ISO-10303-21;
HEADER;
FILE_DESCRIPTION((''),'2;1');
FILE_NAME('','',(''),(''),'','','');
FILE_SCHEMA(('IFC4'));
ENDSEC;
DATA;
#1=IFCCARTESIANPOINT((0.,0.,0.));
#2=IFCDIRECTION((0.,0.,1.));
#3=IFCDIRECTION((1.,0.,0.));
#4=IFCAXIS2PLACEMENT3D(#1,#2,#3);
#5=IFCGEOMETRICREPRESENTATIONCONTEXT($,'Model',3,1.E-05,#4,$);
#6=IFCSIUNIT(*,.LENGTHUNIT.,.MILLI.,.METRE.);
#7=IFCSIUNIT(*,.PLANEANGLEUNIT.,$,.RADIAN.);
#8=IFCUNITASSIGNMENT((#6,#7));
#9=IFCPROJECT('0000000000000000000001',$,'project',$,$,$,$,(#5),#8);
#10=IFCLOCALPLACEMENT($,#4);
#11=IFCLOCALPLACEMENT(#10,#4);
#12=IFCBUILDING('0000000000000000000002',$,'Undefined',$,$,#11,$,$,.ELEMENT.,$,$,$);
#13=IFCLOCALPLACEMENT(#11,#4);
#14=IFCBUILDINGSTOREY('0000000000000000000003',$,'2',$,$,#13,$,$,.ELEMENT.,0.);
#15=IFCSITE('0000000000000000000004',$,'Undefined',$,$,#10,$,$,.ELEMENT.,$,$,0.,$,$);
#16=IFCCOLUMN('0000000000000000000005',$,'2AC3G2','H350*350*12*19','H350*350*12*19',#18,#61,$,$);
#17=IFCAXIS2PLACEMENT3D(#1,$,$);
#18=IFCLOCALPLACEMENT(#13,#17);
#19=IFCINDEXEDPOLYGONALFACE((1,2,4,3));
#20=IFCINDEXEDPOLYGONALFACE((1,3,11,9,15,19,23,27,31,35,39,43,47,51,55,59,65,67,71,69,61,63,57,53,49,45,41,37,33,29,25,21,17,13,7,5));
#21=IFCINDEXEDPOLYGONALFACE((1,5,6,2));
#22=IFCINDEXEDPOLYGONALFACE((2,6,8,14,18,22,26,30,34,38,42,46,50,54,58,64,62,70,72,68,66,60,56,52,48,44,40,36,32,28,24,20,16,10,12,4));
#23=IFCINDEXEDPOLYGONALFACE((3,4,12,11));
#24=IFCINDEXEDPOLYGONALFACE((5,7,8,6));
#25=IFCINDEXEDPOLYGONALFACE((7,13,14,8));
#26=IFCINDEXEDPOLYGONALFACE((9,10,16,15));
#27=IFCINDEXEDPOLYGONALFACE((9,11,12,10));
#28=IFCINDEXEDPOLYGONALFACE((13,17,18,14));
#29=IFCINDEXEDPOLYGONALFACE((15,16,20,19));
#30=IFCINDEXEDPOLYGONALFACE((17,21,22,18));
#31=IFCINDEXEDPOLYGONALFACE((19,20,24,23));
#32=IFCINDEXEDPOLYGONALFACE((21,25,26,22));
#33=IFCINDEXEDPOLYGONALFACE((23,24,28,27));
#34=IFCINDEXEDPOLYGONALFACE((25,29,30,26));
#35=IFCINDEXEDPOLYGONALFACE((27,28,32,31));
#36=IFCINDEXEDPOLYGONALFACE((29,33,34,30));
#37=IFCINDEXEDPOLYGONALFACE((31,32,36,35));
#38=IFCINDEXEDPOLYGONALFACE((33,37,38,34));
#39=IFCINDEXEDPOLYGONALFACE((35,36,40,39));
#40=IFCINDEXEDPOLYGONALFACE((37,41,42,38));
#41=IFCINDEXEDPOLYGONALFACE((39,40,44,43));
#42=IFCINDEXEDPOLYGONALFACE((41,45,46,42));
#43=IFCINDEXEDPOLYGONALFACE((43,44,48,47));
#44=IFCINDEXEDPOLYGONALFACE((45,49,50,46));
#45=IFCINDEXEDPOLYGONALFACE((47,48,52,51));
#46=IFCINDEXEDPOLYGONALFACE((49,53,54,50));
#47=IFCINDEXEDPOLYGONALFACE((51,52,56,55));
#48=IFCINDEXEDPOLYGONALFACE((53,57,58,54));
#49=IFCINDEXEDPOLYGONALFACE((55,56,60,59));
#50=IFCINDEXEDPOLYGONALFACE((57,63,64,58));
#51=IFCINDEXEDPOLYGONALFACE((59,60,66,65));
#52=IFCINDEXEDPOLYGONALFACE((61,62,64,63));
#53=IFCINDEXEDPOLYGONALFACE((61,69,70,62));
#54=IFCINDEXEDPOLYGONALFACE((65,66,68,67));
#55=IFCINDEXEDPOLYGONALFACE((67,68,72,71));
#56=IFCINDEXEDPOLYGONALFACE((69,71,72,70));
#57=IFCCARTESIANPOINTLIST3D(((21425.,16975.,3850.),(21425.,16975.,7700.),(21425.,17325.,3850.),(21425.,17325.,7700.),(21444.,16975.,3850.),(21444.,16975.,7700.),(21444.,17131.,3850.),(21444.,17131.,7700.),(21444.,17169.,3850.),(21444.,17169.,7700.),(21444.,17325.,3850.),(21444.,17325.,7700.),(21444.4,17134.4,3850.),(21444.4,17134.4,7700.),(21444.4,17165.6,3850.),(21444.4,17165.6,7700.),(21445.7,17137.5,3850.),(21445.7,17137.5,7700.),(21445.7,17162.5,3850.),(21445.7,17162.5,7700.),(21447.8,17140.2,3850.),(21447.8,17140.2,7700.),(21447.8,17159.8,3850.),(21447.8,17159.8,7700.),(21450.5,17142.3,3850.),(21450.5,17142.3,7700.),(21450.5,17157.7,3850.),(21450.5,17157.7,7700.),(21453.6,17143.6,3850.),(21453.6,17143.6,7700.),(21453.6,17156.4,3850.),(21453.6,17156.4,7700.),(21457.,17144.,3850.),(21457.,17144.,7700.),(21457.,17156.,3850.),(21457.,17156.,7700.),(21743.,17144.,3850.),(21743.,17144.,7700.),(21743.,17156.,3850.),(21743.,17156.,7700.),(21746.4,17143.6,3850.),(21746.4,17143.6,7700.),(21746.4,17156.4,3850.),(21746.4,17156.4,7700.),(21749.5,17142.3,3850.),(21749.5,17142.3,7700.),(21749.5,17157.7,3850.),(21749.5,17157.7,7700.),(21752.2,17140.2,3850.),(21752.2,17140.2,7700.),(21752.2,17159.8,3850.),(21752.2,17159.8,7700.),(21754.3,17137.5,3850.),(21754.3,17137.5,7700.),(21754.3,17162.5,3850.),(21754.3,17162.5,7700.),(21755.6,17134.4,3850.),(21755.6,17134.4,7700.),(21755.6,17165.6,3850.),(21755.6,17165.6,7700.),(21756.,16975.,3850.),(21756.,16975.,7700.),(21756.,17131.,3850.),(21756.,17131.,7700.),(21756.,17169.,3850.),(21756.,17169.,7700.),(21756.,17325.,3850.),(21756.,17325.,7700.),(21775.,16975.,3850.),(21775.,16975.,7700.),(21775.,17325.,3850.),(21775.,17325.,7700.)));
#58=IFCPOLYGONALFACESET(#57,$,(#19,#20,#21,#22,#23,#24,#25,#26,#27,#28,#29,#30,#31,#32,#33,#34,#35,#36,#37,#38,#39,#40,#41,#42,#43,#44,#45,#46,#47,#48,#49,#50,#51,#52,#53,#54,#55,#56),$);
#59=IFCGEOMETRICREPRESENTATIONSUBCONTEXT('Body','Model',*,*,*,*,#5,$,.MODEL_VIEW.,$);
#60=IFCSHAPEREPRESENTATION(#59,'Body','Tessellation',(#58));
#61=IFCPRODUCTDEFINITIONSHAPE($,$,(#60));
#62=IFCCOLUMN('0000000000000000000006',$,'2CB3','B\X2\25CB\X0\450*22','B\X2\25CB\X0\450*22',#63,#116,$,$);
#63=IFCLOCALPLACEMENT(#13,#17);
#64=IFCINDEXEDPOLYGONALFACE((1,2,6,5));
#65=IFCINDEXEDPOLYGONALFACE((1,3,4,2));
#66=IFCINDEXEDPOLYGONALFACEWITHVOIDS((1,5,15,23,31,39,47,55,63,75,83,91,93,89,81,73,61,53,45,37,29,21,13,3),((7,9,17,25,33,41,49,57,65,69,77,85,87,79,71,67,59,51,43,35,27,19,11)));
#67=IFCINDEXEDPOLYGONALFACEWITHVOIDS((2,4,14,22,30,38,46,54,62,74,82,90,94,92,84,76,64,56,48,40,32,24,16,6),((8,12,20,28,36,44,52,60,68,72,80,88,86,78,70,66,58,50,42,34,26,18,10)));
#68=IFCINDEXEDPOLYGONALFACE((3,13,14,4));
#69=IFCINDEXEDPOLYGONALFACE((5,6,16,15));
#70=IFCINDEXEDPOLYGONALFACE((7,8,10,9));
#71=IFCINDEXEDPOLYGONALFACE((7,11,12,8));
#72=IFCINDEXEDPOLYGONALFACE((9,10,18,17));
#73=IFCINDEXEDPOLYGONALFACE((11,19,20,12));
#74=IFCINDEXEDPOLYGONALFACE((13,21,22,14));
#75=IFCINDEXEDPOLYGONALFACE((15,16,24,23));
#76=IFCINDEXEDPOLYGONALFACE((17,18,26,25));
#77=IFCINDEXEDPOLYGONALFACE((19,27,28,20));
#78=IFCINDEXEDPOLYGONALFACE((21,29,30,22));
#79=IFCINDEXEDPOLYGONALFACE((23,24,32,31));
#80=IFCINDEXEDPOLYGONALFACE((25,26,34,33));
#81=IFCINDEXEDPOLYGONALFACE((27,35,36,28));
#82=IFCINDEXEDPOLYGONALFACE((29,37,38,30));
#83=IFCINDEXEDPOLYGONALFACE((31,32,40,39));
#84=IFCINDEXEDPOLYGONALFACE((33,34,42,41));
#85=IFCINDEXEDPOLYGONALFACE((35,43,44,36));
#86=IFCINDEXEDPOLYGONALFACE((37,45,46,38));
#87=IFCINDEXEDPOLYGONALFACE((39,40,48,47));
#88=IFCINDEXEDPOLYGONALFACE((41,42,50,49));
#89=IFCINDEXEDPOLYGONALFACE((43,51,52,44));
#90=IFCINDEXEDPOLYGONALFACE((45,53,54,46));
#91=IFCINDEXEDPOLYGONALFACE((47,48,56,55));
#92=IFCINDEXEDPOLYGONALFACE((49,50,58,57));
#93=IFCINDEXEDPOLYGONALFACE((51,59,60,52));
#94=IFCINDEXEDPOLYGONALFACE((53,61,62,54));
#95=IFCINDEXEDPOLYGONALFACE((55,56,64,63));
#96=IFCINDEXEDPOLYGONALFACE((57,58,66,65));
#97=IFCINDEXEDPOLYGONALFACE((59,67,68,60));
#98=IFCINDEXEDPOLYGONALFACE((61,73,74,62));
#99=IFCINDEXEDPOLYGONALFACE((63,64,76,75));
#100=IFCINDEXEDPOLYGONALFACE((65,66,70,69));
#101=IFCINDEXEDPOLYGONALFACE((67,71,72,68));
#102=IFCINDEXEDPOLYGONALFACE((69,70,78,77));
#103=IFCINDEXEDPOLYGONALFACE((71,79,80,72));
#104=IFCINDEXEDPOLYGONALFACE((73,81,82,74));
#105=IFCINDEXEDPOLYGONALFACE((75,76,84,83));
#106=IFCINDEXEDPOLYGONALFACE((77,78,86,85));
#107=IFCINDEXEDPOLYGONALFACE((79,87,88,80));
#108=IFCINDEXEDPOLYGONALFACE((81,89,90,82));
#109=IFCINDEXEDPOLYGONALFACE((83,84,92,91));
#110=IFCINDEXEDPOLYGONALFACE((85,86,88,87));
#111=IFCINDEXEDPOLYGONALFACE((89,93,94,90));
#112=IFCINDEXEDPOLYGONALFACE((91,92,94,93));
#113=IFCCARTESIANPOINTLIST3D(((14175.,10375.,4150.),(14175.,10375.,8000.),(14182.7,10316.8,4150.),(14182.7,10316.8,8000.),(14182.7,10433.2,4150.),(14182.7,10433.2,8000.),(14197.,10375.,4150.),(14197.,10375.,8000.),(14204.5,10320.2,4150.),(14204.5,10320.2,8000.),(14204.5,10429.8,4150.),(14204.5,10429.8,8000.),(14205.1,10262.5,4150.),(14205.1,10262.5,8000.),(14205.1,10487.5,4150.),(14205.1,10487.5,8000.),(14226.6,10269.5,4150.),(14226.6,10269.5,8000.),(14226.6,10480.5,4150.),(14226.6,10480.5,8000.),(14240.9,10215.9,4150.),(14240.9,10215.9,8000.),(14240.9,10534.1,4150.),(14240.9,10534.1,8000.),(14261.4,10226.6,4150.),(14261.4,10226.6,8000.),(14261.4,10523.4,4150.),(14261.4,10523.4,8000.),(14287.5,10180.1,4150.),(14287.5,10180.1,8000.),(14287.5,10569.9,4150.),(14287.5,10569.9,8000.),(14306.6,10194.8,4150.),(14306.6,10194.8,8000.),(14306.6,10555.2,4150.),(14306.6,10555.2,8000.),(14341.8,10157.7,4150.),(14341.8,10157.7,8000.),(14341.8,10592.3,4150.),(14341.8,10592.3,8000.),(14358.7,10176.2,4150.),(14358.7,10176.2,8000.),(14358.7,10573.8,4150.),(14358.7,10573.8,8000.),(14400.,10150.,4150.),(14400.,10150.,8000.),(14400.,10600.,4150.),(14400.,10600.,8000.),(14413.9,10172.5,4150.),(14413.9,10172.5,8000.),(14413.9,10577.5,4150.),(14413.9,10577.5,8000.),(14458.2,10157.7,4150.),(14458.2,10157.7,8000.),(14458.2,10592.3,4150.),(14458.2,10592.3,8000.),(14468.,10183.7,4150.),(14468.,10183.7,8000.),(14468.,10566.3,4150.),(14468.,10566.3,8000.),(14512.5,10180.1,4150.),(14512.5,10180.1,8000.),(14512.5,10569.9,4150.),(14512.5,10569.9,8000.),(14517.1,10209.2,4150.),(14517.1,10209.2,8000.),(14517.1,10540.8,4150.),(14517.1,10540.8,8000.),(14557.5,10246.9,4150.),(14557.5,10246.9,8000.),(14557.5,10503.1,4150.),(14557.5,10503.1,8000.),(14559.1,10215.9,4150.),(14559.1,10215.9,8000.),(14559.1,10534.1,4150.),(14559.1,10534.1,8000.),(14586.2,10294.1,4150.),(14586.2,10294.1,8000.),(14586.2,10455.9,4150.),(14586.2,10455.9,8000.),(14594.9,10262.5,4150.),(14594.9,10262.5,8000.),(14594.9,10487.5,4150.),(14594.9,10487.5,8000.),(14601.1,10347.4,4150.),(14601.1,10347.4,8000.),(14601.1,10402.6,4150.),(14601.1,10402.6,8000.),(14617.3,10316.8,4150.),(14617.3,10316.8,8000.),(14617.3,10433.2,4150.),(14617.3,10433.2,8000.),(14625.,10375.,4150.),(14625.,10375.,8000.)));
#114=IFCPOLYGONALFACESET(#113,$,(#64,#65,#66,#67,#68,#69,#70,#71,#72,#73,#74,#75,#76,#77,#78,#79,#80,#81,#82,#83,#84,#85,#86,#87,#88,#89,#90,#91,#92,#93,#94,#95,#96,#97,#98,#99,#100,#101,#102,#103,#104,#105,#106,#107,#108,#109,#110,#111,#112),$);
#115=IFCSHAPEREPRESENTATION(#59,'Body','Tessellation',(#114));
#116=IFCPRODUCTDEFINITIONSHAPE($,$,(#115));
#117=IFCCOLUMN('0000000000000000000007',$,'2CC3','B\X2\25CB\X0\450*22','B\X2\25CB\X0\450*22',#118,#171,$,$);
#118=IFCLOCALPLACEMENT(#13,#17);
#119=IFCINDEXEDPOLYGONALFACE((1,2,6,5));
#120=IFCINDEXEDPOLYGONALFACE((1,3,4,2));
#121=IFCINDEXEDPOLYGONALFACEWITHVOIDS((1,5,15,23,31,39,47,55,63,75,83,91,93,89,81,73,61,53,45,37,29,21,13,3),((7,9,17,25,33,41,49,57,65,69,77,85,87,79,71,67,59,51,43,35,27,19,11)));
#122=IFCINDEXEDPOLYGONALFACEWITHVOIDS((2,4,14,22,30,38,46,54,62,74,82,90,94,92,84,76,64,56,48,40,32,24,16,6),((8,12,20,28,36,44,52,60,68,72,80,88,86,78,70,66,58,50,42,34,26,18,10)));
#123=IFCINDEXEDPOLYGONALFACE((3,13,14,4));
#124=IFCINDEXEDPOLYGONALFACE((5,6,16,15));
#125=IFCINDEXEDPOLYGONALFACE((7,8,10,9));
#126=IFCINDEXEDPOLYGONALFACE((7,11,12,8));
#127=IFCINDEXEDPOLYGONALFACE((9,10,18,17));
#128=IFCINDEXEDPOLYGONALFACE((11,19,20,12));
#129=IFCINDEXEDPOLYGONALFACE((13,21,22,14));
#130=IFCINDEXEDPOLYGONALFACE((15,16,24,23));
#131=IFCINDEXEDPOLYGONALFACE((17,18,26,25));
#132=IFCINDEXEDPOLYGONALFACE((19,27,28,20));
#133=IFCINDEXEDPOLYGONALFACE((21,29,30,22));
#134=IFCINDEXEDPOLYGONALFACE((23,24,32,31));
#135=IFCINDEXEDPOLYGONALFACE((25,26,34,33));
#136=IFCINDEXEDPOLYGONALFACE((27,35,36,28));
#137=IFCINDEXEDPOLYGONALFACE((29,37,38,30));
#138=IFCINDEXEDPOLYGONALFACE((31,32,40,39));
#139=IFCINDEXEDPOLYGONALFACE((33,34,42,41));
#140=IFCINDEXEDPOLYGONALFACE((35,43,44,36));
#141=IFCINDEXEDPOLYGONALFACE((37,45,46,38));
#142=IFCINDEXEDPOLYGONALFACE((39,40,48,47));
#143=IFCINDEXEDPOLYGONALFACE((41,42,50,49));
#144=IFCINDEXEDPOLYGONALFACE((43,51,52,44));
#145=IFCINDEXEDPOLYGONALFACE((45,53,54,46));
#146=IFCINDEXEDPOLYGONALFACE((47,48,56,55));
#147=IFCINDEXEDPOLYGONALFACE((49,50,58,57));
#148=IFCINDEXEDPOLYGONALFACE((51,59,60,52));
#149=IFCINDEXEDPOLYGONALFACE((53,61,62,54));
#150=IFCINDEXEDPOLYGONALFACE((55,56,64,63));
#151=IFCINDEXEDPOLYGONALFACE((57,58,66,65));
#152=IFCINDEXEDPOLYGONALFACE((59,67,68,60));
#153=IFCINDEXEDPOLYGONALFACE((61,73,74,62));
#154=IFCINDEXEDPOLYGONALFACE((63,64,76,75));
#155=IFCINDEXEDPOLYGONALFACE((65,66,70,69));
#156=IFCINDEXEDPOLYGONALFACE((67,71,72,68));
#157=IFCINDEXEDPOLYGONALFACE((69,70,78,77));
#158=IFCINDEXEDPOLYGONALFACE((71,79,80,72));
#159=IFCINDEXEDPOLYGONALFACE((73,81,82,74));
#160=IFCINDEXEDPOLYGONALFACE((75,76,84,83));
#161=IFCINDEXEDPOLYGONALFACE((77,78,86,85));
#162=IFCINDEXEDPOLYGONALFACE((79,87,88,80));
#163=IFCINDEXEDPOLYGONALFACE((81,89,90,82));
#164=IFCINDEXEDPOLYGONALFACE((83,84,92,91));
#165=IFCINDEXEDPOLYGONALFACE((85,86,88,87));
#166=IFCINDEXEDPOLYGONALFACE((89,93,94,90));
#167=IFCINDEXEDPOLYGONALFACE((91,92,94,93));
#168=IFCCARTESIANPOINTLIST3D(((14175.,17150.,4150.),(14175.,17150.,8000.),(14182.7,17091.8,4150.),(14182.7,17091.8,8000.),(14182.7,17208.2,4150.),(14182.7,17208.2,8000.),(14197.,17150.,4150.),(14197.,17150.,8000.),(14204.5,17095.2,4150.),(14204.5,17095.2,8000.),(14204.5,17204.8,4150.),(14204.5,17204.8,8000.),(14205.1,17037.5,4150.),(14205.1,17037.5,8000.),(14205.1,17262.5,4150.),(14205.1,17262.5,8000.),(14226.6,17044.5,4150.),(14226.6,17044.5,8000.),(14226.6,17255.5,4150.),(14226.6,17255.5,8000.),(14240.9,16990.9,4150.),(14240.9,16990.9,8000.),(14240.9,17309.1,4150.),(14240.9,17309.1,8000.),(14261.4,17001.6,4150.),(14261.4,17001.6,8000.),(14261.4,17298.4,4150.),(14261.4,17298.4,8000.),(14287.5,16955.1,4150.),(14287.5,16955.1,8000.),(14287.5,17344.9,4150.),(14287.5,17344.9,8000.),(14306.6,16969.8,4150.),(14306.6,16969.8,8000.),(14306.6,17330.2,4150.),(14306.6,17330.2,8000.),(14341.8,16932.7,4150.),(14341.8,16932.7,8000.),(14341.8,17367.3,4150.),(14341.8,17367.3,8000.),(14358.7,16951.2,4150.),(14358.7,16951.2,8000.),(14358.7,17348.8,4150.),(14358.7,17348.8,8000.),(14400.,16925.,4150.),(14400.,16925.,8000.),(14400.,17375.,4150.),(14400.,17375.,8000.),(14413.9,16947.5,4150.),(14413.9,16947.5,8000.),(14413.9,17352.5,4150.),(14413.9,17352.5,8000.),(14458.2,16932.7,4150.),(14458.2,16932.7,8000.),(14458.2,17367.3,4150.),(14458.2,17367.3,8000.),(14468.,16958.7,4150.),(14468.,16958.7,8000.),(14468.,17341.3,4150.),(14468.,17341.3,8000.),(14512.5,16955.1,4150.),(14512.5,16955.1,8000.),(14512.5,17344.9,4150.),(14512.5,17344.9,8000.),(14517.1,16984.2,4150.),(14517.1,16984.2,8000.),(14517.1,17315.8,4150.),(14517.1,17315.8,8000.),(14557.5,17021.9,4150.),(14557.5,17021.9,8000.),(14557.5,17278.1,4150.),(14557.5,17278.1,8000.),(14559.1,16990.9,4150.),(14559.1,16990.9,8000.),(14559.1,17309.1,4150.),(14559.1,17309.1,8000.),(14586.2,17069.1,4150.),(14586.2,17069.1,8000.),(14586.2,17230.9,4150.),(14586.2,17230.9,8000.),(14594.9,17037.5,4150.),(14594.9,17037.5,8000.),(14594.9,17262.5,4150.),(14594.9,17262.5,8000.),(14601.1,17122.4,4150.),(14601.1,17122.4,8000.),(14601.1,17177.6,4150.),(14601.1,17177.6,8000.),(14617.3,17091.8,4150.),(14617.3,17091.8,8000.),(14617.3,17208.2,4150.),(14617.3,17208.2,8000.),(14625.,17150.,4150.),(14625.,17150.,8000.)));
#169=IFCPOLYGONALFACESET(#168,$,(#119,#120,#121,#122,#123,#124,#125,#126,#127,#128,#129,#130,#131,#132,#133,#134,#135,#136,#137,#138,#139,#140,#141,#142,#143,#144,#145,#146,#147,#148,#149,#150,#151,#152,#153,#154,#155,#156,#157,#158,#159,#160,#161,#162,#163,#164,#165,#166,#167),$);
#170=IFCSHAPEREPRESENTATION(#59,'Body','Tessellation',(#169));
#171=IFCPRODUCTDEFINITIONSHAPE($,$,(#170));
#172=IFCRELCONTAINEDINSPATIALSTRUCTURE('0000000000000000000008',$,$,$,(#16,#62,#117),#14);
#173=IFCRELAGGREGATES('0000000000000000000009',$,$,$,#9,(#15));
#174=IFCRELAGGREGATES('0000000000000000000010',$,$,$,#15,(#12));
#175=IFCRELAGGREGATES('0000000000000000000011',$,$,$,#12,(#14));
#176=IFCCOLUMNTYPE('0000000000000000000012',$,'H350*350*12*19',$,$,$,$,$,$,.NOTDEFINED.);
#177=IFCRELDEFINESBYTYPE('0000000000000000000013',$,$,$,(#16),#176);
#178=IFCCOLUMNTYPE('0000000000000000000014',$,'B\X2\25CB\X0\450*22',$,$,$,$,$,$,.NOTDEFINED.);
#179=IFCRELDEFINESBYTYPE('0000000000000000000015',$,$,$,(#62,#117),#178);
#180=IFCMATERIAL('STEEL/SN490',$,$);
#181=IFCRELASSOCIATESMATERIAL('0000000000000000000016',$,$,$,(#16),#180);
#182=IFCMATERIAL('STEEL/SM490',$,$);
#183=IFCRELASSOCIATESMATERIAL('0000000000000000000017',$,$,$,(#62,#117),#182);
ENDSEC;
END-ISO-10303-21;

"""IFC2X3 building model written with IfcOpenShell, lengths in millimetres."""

from ifc_helpers import new_model, si_unit, frame, origin_with_axes, origin_2d_with_axis, place, context, subcontext, project, spatial, hollow_circle, i_section, extrude, material, type_object, element, save


model = new_model("IFC2X3")

# Units and contexts
model_context = context("Model", 3, precision=1e-05, world=origin_with_axes())
body_context = subcontext(model_context, "Body", "Model", "MODEL_VIEW")
ifc_project = project(units=[si_unit("LENGTHUNIT", "METRE", prefix="MILLI"), si_unit("PLANEANGLEUNIT", "RADIAN")], contexts=[model_context])

# Site, building, storey
site_placement = place(None, origin_with_axes())
site = spatial("IfcSite", under=ifc_project, at=site_placement, Name="Undefined", CompositionType="ELEMENT", RefElevation=0.0)
building_placement = place(site_placement, origin_with_axes())
building = spatial("IfcBuilding", under=site, at=building_placement, Name="Undefined", CompositionType="ELEMENT")
storey_placement = place(building_placement, origin_with_axes())
storey = spatial("IfcBuildingStorey", under=building, at=storey_placement, Name="2", CompositionType="ELEMENT", Elevation=0.0)

# Columns
ifc_material_1 = material(Name="STEEL/SN490")
column_type_1 = type_object("IfcColumnType", Name="H350*350*12*19", PredefinedType="NOTDEFINED")
column_placement = place(storey_placement, frame((21600.0, 17150.0, 3850.0), z_axis=(0.0, 0.0, 1.0), x_axis=(-1.0, 0.0, 0.0)))
element("IfcColumn", 1, at=column_placement, inside=storey, type_object=column_type_1, material=ifc_material_1, Name="2AC3G2", Description="H350*350*12*19", ObjectType="H350*350*12*19", context=body_context, shape_type="SweptSolid", body=[
    extrude(i_section(OverallWidth=350.0, OverallDepth=350.0, WebThickness=12.0, FlangeThickness=19.0, FilletRadius=13.0, at=origin_2d_with_axis()), frame((0.0, 0.0, 3850.0), z_axis=(0.0, 0.0, -1.0), x_axis=(0.0, 1.0, 0.0)), (0.0, 0.0, 1.0), 3850.0),
])
ifc_material_2 = material(Name="STEEL/SM490")
column_type_2 = type_object("IfcColumnType", Name="B○450*22", PredefinedType="NOTDEFINED")
for number, where, z_axis, x_axis, name in (
    (2, (14400.0, 10375.0, 4150.0), (0.0, 0.0, 1.0), (0.0, 1.0, 0.0), "2CB3"),
    (3, (14400.0, 17150.0, 4150.0), (0.0, 0.0, 1.0), (0.0, 1.0, 0.0), "2CC3"),
):
    element("IfcColumn", number, at=place(storey_placement, frame(where, z_axis=z_axis, x_axis=x_axis)), inside=storey, type_object=column_type_2, material=ifc_material_2, Name=name, Description="B○450*22", ObjectType="B○450*22", context=body_context, shape_type="SweptSolid", body=[
        extrude(hollow_circle(Radius=225.0, WallThickness=22.0, at=origin_2d_with_axis()), frame((0.0, 0.0, 3850.0), z_axis=(0.0, 0.0, -1.0), x_axis=(0.0, 1.0, 0.0)), (0.0, 0.0, 1.0), 3850.0),
    ])

save(model, "model.ifc")
